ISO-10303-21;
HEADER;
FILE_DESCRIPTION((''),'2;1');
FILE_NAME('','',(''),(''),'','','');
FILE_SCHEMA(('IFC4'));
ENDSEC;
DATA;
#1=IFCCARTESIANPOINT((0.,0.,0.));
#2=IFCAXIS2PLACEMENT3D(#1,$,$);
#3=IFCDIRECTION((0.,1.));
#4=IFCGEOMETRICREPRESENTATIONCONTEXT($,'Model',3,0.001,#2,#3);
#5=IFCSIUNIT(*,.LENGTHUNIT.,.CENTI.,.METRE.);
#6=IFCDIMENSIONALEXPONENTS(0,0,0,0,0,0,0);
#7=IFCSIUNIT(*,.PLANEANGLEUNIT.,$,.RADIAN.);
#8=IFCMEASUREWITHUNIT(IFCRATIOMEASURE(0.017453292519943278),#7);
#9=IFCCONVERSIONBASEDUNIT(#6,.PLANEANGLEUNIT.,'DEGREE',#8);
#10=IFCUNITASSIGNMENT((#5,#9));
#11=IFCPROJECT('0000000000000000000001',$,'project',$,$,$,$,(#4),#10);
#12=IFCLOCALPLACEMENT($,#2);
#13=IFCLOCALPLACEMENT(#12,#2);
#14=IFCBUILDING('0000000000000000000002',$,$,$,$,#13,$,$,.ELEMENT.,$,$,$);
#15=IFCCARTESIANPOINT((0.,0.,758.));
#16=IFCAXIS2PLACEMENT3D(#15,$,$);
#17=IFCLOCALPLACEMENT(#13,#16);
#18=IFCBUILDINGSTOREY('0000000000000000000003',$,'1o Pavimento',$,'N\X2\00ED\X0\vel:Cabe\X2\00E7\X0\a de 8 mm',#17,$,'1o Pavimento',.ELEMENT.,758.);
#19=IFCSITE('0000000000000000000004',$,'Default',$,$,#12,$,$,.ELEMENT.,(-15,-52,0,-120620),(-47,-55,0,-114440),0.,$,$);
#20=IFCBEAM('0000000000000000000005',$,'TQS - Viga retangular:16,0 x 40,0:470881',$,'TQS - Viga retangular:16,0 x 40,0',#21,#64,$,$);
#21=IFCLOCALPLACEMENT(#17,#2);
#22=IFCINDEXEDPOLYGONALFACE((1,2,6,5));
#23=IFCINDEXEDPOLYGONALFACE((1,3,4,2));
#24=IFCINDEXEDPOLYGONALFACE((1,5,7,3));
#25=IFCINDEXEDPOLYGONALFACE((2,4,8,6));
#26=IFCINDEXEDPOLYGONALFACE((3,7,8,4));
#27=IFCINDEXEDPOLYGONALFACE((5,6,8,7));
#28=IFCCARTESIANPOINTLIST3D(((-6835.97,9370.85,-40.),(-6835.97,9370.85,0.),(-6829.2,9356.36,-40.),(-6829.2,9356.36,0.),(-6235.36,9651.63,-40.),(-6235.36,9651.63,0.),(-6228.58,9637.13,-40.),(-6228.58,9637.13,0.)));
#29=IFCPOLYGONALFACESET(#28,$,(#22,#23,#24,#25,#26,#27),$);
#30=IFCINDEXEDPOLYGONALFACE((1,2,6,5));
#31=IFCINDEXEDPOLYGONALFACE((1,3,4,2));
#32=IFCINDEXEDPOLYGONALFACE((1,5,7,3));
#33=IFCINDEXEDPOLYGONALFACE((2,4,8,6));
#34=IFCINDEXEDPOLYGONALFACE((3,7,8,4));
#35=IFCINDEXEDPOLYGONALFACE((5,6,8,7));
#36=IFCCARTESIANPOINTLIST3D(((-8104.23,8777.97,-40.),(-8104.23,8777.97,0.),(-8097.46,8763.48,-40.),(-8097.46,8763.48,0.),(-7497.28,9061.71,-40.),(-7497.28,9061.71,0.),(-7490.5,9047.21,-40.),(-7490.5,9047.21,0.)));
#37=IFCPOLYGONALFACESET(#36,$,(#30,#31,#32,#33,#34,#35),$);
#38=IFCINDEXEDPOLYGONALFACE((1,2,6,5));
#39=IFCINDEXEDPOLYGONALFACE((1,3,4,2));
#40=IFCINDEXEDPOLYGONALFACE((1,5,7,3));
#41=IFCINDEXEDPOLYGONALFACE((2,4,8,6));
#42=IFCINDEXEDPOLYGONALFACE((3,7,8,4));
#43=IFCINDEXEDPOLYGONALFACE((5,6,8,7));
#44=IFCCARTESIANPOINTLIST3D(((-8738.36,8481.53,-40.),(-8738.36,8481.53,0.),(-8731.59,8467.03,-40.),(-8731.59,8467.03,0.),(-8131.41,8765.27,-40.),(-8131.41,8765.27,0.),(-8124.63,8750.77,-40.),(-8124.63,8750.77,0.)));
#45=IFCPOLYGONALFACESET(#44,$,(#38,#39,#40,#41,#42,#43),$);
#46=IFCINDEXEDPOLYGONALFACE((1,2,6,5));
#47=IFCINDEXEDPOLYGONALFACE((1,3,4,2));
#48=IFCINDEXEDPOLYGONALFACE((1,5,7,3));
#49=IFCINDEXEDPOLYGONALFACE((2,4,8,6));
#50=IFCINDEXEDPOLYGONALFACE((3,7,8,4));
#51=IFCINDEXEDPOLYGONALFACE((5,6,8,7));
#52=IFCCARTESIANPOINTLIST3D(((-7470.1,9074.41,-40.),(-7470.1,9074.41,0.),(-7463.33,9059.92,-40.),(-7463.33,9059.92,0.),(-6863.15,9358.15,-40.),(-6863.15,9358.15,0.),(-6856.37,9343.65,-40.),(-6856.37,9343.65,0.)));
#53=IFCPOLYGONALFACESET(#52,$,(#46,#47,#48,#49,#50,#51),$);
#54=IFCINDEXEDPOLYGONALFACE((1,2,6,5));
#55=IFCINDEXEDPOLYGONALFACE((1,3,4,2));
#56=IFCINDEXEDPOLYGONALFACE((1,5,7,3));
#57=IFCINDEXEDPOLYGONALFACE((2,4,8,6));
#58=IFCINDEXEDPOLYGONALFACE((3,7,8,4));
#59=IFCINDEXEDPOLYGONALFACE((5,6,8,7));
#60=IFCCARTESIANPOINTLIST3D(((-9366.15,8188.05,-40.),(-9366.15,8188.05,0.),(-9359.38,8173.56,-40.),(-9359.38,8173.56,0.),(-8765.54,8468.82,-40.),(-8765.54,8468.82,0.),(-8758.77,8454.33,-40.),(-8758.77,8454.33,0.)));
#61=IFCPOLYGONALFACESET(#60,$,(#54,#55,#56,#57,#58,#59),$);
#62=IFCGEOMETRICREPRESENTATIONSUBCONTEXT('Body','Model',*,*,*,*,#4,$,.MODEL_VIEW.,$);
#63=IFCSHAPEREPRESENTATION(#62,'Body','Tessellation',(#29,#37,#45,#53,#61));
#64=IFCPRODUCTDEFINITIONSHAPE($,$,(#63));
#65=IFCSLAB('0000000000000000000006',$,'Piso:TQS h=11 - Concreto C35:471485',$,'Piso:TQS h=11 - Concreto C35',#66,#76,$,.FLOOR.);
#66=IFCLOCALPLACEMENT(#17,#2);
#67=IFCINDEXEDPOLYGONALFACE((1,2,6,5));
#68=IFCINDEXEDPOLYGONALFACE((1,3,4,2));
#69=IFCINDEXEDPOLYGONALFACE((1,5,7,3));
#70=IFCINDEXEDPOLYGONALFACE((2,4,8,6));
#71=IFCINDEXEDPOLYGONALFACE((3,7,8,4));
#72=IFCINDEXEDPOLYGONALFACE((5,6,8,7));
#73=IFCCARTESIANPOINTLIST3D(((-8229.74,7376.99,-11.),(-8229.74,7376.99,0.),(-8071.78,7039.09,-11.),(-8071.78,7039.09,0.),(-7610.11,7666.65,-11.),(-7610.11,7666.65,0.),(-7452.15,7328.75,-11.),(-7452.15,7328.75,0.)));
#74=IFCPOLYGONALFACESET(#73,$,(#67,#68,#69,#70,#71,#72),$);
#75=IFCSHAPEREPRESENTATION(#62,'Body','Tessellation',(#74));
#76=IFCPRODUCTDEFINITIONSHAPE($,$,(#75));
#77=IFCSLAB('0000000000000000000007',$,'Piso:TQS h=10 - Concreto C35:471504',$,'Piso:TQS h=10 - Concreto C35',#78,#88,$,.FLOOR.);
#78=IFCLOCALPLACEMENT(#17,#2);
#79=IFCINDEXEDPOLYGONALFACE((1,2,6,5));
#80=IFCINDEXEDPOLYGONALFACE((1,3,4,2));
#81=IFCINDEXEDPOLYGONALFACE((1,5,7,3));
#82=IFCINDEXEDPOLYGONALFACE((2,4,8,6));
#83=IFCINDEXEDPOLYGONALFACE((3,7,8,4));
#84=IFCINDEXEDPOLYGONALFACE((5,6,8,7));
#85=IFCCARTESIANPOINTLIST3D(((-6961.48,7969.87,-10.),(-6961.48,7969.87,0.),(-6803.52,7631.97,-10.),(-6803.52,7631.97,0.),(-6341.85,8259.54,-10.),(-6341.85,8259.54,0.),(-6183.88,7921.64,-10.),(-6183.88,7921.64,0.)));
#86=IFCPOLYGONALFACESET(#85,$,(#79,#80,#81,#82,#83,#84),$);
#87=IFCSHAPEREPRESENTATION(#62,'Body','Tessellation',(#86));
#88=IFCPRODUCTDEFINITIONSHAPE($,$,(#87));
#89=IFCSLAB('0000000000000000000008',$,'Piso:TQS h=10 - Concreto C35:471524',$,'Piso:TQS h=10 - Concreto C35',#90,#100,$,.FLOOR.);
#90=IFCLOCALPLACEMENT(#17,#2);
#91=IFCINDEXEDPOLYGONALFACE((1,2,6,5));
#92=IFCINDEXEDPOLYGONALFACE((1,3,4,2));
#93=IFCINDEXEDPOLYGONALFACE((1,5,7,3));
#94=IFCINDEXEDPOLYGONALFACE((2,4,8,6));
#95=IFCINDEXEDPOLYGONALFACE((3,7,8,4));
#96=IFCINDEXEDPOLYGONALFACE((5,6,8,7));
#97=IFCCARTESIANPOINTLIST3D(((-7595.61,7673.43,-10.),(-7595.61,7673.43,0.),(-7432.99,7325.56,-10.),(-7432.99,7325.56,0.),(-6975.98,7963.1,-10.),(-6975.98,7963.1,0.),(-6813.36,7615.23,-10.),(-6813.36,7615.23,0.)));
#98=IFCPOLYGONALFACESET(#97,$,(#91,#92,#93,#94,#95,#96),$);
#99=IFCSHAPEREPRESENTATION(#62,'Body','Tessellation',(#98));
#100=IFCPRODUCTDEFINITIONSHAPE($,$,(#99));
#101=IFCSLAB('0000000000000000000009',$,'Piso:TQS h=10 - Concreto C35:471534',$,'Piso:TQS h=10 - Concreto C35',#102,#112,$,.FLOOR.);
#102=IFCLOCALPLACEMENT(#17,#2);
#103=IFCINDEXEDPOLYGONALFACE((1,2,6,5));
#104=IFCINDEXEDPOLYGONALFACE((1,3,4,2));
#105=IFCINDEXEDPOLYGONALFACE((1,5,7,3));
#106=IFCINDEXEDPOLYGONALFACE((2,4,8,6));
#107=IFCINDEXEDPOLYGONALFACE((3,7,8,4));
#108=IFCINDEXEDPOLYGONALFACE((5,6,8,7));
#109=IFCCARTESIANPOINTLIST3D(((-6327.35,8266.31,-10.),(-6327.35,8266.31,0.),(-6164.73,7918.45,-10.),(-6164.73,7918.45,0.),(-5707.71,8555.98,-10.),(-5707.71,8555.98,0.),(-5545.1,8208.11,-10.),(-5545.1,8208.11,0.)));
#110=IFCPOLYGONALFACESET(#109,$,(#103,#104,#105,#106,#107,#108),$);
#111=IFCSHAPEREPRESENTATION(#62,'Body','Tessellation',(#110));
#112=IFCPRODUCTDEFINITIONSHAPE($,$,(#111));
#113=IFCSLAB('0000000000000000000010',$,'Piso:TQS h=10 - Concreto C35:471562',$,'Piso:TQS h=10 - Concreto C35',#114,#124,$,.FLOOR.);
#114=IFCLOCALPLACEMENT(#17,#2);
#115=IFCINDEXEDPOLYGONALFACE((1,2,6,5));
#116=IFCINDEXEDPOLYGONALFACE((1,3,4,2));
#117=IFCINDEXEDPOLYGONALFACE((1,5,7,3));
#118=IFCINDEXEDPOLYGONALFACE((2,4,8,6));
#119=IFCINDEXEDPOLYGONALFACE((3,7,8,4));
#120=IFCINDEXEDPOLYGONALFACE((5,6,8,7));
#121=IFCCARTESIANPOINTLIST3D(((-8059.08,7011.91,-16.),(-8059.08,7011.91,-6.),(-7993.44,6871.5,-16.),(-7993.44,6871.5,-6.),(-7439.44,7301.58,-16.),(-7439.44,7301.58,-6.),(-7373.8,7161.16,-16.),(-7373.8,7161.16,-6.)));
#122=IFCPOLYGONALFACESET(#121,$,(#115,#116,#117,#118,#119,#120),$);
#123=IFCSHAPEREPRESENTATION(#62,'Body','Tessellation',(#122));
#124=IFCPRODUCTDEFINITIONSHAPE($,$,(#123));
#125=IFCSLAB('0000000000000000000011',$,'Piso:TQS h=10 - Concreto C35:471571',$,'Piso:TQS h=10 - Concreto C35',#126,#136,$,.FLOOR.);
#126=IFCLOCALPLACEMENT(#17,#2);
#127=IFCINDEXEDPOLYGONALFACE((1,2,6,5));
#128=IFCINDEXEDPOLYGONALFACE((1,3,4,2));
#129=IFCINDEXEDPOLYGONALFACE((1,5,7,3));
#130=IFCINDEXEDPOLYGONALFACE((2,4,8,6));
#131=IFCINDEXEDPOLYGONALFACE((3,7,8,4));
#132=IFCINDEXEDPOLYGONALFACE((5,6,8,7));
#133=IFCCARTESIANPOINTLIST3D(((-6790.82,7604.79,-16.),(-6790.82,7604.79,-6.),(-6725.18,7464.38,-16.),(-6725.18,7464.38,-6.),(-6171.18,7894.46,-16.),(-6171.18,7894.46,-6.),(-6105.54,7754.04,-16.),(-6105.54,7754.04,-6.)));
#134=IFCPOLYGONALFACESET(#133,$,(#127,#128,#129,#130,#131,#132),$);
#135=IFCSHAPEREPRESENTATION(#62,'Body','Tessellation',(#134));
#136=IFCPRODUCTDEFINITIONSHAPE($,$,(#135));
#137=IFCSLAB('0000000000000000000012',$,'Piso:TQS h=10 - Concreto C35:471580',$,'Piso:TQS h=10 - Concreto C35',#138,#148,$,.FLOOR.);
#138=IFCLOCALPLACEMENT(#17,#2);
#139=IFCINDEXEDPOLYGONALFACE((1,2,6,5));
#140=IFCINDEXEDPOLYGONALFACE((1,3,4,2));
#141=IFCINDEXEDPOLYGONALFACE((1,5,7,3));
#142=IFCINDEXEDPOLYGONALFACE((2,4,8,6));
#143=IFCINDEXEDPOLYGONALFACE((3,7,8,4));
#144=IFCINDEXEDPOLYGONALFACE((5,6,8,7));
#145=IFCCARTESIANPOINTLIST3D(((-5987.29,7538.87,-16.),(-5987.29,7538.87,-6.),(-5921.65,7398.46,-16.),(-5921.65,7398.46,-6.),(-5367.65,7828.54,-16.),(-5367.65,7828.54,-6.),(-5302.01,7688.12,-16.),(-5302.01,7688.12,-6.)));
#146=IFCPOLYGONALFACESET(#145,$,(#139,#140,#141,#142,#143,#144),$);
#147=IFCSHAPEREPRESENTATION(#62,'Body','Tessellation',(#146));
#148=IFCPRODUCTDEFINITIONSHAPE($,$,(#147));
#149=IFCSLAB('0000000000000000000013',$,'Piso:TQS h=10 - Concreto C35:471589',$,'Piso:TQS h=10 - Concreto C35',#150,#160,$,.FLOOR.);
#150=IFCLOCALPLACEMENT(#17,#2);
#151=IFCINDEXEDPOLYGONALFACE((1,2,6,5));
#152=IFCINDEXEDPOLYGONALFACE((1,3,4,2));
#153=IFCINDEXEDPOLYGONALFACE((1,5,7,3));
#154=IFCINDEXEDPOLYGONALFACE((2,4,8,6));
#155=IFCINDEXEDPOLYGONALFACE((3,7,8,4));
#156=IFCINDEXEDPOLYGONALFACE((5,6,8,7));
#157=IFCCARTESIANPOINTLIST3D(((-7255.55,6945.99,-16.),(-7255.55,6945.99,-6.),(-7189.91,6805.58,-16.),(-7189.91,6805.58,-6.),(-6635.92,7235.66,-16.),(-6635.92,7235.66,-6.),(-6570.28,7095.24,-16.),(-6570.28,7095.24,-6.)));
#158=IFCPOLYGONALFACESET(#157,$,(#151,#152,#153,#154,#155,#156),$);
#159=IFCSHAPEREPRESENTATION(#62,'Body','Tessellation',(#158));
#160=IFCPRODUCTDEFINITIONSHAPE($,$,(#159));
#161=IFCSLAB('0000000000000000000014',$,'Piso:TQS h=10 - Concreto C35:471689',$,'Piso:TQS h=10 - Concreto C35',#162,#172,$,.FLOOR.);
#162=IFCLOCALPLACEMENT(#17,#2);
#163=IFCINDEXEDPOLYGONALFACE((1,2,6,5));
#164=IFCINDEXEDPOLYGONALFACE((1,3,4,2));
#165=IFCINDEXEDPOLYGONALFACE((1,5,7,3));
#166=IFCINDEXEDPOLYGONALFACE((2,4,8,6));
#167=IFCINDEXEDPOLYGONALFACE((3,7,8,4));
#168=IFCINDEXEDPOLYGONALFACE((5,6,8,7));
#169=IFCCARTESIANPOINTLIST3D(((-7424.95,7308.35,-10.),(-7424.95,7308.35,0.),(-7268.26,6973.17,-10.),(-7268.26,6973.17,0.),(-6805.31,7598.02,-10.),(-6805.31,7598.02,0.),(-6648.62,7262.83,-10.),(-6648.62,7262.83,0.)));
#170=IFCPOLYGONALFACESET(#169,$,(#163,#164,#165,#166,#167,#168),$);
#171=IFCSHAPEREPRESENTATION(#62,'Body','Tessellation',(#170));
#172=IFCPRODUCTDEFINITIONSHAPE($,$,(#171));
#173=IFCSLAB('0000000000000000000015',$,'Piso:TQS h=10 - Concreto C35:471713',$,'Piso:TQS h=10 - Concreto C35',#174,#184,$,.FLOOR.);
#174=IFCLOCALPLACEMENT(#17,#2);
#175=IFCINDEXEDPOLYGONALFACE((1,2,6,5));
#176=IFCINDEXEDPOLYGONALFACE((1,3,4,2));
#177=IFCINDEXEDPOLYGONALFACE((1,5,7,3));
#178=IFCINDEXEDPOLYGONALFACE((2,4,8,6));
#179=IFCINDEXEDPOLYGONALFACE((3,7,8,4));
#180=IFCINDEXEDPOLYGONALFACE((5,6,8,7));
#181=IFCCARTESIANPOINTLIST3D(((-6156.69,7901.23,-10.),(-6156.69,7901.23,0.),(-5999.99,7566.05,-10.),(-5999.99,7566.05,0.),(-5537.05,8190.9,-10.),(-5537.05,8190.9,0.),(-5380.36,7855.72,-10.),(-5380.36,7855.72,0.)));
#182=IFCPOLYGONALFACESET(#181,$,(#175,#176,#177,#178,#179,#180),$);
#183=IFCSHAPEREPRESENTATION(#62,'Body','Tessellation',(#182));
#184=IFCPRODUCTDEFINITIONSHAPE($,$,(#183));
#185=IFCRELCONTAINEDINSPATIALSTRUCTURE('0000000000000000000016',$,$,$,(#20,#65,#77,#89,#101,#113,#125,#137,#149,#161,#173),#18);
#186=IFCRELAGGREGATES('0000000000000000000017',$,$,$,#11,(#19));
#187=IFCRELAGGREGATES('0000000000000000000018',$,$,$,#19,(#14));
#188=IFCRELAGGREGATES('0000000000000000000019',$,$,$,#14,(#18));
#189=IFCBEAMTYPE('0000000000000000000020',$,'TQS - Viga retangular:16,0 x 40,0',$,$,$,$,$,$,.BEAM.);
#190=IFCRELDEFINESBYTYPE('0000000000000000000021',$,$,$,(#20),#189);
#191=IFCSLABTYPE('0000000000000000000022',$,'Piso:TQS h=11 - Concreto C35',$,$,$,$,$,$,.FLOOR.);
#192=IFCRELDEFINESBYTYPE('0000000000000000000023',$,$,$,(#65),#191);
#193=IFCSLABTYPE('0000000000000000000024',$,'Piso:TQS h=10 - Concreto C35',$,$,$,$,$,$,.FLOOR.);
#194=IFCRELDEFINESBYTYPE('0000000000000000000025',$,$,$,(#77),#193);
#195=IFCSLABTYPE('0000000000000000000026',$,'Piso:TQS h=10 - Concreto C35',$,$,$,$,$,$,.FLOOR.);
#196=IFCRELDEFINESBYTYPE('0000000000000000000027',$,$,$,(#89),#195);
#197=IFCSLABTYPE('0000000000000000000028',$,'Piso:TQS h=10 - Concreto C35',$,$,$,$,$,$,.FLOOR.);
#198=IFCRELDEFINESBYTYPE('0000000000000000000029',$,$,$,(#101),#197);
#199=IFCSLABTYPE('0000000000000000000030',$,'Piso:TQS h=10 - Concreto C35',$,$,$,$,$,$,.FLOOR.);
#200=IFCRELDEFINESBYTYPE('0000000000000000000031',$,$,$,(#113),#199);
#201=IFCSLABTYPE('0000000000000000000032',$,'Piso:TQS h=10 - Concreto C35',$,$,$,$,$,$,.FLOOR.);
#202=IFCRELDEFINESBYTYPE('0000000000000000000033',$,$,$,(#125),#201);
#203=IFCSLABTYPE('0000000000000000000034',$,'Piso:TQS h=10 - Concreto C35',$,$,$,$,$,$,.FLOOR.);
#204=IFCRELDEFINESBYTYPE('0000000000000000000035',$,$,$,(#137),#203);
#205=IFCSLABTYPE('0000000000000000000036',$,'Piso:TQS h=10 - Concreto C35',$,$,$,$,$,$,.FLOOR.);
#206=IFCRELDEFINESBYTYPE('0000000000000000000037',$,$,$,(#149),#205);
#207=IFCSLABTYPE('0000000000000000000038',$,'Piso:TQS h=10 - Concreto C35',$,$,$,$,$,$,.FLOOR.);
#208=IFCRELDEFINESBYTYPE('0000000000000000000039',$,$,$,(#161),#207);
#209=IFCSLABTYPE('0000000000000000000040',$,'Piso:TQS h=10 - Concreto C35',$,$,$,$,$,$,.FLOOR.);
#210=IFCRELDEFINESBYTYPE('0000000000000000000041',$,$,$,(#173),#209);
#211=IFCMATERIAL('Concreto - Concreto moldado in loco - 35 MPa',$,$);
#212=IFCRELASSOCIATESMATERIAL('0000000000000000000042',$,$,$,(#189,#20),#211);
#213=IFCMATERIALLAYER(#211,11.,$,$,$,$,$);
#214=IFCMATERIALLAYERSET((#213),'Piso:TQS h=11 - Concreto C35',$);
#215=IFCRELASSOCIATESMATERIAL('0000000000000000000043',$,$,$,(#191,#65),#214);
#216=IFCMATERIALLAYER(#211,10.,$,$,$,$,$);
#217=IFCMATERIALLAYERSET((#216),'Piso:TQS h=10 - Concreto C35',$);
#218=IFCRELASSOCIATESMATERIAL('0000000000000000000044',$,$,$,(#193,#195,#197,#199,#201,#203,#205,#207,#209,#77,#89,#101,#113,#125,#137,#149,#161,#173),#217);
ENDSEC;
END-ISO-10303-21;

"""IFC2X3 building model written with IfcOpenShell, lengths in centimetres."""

from ifc_helpers import new_model, entity, si_unit, converted_unit, direction, frame, frame_2d, origin, origin_2d_with_axis, place, context, subcontext, project, spatial, rectangle, extrude, source, transform, mapped, material, layer, layer_set, layer_usage, type_object, type_shapes, element, save


model = new_model("IFC2X3")

# Units and contexts
model_context = context("Model", 3, precision=0.001, world=origin(), true_north=direction((0.0, 1.0)))
body_context = subcontext(model_context, "Body", "Model", "MODEL_VIEW")
ifc_project = project(units=[si_unit("LENGTHUNIT", "METRE", prefix="CENTI"), converted_unit("PLANEANGLEUNIT", "DEGREE", entity("IfcRatioMeasure", 0.017453292519943278), si_unit("PLANEANGLEUNIT", "RADIAN"), dimensions=[0, 0, 0, 0, 0, 0, 0])], contexts=[model_context])

# Site, building, storey
site_placement = place(None, origin())
site = spatial("IfcSite", under=ifc_project, at=site_placement, Name="Default", CompositionType="ELEMENT", RefLatitude=(-15, -52, 0, -120620), RefLongitude=(-47, -55, 0, -114440), RefElevation=0.0)
building_placement = place(site_placement, origin())
building = spatial("IfcBuilding", under=site, at=building_placement, CompositionType="ELEMENT")
storey_placement = place(building_placement, frame((0.0, 0.0, 758.0)))
storey = spatial("IfcBuildingStorey", under=building, at=storey_placement, Name="1o Pavimento", ObjectType="Nível:Cabeça de 8 mm", LongName="1o Pavimento", CompositionType="ELEMENT", Elevation=758.0)

# Shared definitions
ifc_material = material(Name="Concreto - Concreto moldado in loco - 35 MPa")

# Beam
beam_type_1 = type_object("IfcBeamType", Name="TQS - Viga retangular:16,0 x 40,0", PredefinedType="BEAM", material=ifc_material)
shared_shape_1 = source(origin(), body_context, "Body", "SweptSolid", [
    extrude(rectangle(XDim=40.0, YDim=16.0, at=origin_2d_with_axis()), frame((-6832.58, 9363.61, 738.0), z_axis=(0.905902, 0.423488, 0.0), x_axis=(0.0, 0.0, 1.0)), (0.0, 0.0, 1.0), 663.0),
    extrude(rectangle(XDim=40.0, YDim=16.0, at=frame_2d((0.0, 0.0), x_axis=(1.0, 0.0))), frame((-8100.85, 8770.72, 738.0), z_axis=(0.905902, 0.423488, 0.0), x_axis=(0.0, 0.0, 1.0)), (0.0, 0.0, 1.0), 670.0),
    extrude(rectangle(XDim=40.0, YDim=16.0, at=origin_2d_with_axis()), frame((-8734.98, 8474.28, 738.0), z_axis=(0.905902, 0.423488, 0.0), x_axis=(0.0, 0.0, 1.0)), (0.0, 0.0, 1.0), 670.0),
    extrude(rectangle(XDim=40.0, YDim=16.0, at=frame_2d((0.0, 0.0), x_axis=(1.0, 0.0))), frame((-7466.71, 9067.16, 738.0), z_axis=(0.905902, 0.423488, 0.0), x_axis=(0.0, 0.0, 1.0)), (0.0, 0.0, 1.0), 670.0),
    extrude(rectangle(XDim=40.0, YDim=16.0, at=frame_2d((0.0, 0.0), x_axis=(1.0, 0.0))), frame((-9362.77, 8180.81, 738.0), z_axis=(0.905902, 0.423488, 0.0), x_axis=(0.0, 0.0, 1.0)), (0.0, 0.0, 1.0), 663.0),
])
type_shapes(beam_type_1, [shared_shape_1])
beam_1_placement = place(storey_placement, frame((0.0, 0.0, -758.0)))
element("IfcBeam", 1, at=beam_1_placement, inside=storey, type_object=beam_type_1, material=ifc_material, Name="TQS - Viga retangular:16,0 x 40,0:470881", ObjectType="TQS - Viga retangular:16,0 x 40,0", context=body_context, shape_type="MappedRepresentation", body=[
    mapped(shared_shape_1, transform((0.0, 0.0, 0.0), scale=1.0)),
])

# Slabs
ifc_layer_1 = layer(ifc_material, 11.0)
ifc_layer_set_1 = layer_set([ifc_layer_1], Name="Piso:TQS h=11 - Concreto C35")
ifc_layer_usage_1 = layer_usage(ifc_layer_set_1, "AXIS3", "POSITIVE", 0.0)
slab_type_1 = type_object("IfcSlabType", Name="Piso:TQS h=11 - Concreto C35", PredefinedType="FLOOR", material=ifc_layer_set_1)
slab_1_placement = place(storey_placement, origin())
element("IfcSlab", 2, at=slab_1_placement, inside=storey, type_object=slab_type_1, material=ifc_layer_usage_1, Name="Piso:TQS h=11 - Concreto C35:471485", ObjectType="Piso:TQS h=11 - Concreto C35", PredefinedType="FLOOR", context=body_context, shape_type="SweptSolid", body=[
    extrude(rectangle(XDim=684.0, YDim=373.0, at=frame_2d((0.0, 0.0), x_axis=(1.0, 0.0))), frame((-7840.95, 7352.87, 0.0), z_axis=(0.0, 0.0, -1.0), x_axis=(-0.905902, -0.423488, 0.0)), (0.0, 0.0, 1.0), 11.0),
])
ifc_layer_2 = layer(ifc_material, 10.0)
ifc_layer_set_2 = layer_set([ifc_layer_2], Name="Piso:TQS h=10 - Concreto C35")
ifc_layer_usage_2 = layer_usage(ifc_layer_set_2, "AXIS3", "POSITIVE", 0.0)
slab_type_2 = type_object("IfcSlabType", Name="Piso:TQS h=10 - Concreto C35", PredefinedType="FLOOR", material=ifc_layer_set_2)
slab_2_placement = place(storey_placement, origin())
element("IfcSlab", 3, at=slab_2_placement, inside=storey, type_object=slab_type_2, material=ifc_layer_usage_2, Name="Piso:TQS h=10 - Concreto C35:471504", ObjectType="Piso:TQS h=10 - Concreto C35", PredefinedType="FLOOR", context=body_context, shape_type="SweptSolid", body=[
    extrude(rectangle(XDim=684.0, YDim=373.0, at=frame_2d((0.0, 0.0), x_axis=(1.0, 0.0))), frame((-6572.68, 7945.75, 0.0), z_axis=(0.0, 0.0, -1.0), x_axis=(0.905902, 0.423488, 0.0)), (0.0, 0.0, 1.0), 10.0),
])
ifc_layer_usage_3 = layer_usage(ifc_layer_set_2, "AXIS3", "POSITIVE", 0.0)
slab_type_3 = type_object("IfcSlabType", Name="Piso:TQS h=10 - Concreto C35", PredefinedType="FLOOR", material=ifc_layer_set_2)
slab_3_placement = place(storey_placement, origin())
element("IfcSlab", 4, at=slab_3_placement, inside=storey, type_object=slab_type_3, material=ifc_layer_usage_3, Name="Piso:TQS h=10 - Concreto C35:471524", ObjectType="Piso:TQS h=10 - Concreto C35", PredefinedType="FLOOR", context=body_context, shape_type="SweptSolid", body=[
    extrude(rectangle(XDim=384.0, YDim=684.0, at=frame_2d((0.0, 0.0), x_axis=(1.0, 0.0))), frame((-7204.49, 7644.33, 0.0), z_axis=(0.0, 0.0, -1.0), x_axis=(0.423488, -0.905902, 0.0)), (0.0, 0.0, 1.0), 10.0),
])
ifc_layer_usage_4 = layer_usage(ifc_layer_set_2, "AXIS3", "POSITIVE", 0.0)
slab_type_4 = type_object("IfcSlabType", Name="Piso:TQS h=10 - Concreto C35", PredefinedType="FLOOR", material=ifc_layer_set_2)
slab_4_placement = place(storey_placement, origin())
element("IfcSlab", 5, at=slab_4_placement, inside=storey, type_object=slab_type_4, material=ifc_layer_usage_4, Name="Piso:TQS h=10 - Concreto C35:471534", ObjectType="Piso:TQS h=10 - Concreto C35", PredefinedType="FLOOR", context=body_context, shape_type="SweptSolid", body=[
    extrude(rectangle(XDim=684.0, YDim=384.0, at=frame_2d((0.0, 0.0), x_axis=(1.0, 0.0))), frame((-5936.22, 8237.21, 0.0), z_axis=(0.0, 0.0, -1.0), x_axis=(0.905902, 0.423488, 0.0)), (0.0, 0.0, 1.0), 10.0),
])
ifc_layer_usage_5 = layer_usage(ifc_layer_set_2, "AXIS3", "POSITIVE", 0.0)
slab_type_5 = type_object("IfcSlabType", Name="Piso:TQS h=10 - Concreto C35", PredefinedType="FLOOR", material=ifc_layer_set_2)
slab_5_placement = place(storey_placement, origin())
element("IfcSlab", 6, at=slab_5_placement, inside=storey, type_object=slab_type_5, material=ifc_layer_usage_5, Name="Piso:TQS h=10 - Concreto C35:471562", ObjectType="Piso:TQS h=10 - Concreto C35", PredefinedType="FLOOR", context=body_context, shape_type="SweptSolid", body=[
    extrude(rectangle(XDim=155.0, YDim=684.0, at=frame_2d((0.0, 0.0), x_axis=(1.0, 0.0))), frame((-7716.44, 7086.54, -6.0), z_axis=(0.0, 0.0, -1.0), x_axis=(0.423488, -0.905902, 0.0)), (0.0, 0.0, 1.0), 10.0),
])
ifc_layer_usage_6 = layer_usage(ifc_layer_set_2, "AXIS3", "POSITIVE", 0.0)
slab_type_6 = type_object("IfcSlabType", Name="Piso:TQS h=10 - Concreto C35", PredefinedType="FLOOR", material=ifc_layer_set_2)
slab_6_placement = place(storey_placement, origin())
element("IfcSlab", 7, at=slab_6_placement, inside=storey, type_object=slab_type_6, material=ifc_layer_usage_6, Name="Piso:TQS h=10 - Concreto C35:471571", ObjectType="Piso:TQS h=10 - Concreto C35", PredefinedType="FLOOR", context=body_context, shape_type="SweptSolid", body=[
    extrude(rectangle(XDim=155.0, YDim=684.0, at=frame_2d((0.0, 0.0), x_axis=(1.0, 0.0))), frame((-6448.18, 7679.42, -6.0), z_axis=(0.0, 0.0, -1.0), x_axis=(0.423488, -0.905902, 0.0)), (0.0, 0.0, 1.0), 10.0),
])
ifc_layer_usage_7 = layer_usage(ifc_layer_set_2, "AXIS3", "POSITIVE", 0.0)
slab_type_7 = type_object("IfcSlabType", Name="Piso:TQS h=10 - Concreto C35", PredefinedType="FLOOR", material=ifc_layer_set_2)
slab_7_placement = place(storey_placement, origin())
element("IfcSlab", 8, at=slab_7_placement, inside=storey, type_object=slab_type_7, material=ifc_layer_usage_7, Name="Piso:TQS h=10 - Concreto C35:471580", ObjectType="Piso:TQS h=10 - Concreto C35", PredefinedType="FLOOR", context=body_context, shape_type="SweptSolid", body=[
    extrude(rectangle(XDim=684.0, YDim=155.0, at=frame_2d((0.0, 0.0), x_axis=(1.0, 0.0))), frame((-5644.65, 7613.5, -6.0), z_axis=(0.0, 0.0, -1.0), x_axis=(0.905902, 0.423488, 0.0)), (0.0, 0.0, 1.0), 10.0),
])
ifc_layer_usage_8 = layer_usage(ifc_layer_set_2, "AXIS3", "POSITIVE", 0.0)
slab_type_8 = type_object("IfcSlabType", Name="Piso:TQS h=10 - Concreto C35", PredefinedType="FLOOR", material=ifc_layer_set_2)
slab_8_placement = place(storey_placement, origin())
element("IfcSlab", 9, at=slab_8_placement, inside=storey, type_object=slab_type_8, material=ifc_layer_usage_8, Name="Piso:TQS h=10 - Concreto C35:471589", ObjectType="Piso:TQS h=10 - Concreto C35", PredefinedType="FLOOR", context=body_context, shape_type="SweptSolid", body=[
    extrude(rectangle(XDim=684.0, YDim=155.0, at=frame_2d((0.0, 0.0), x_axis=(1.0, 0.0))), frame((-6912.91, 7020.62, -6.0), z_axis=(0.0, 0.0, -1.0), x_axis=(0.905902, 0.423488, 0.0)), (0.0, 0.0, 1.0), 10.0),
])
ifc_layer_usage_9 = layer_usage(ifc_layer_set_2, "AXIS3", "POSITIVE", 0.0)
slab_type_9 = type_object("IfcSlabType", Name="Piso:TQS h=10 - Concreto C35", PredefinedType="FLOOR", material=ifc_layer_set_2)
slab_9_placement = place(storey_placement, origin())
element("IfcSlab", 10, at=slab_9_placement, inside=storey, type_object=slab_type_9, material=ifc_layer_usage_9, Name="Piso:TQS h=10 - Concreto C35:471689", ObjectType="Piso:TQS h=10 - Concreto C35", PredefinedType="FLOOR", context=body_context, shape_type="SweptSolid", body=[
    extrude(rectangle(XDim=684.0, YDim=370.0, at=origin_2d_with_axis()), frame((-7036.78, 7285.59, 0.0), z_axis=(0.0, 0.0, -1.0), x_axis=(-0.905902, -0.423488, 0.0)), (0.0, 0.0, 1.0), 10.0),
])
ifc_layer_usage_10 = layer_usage(ifc_layer_set_2, "AXIS3", "POSITIVE", 0.0)
slab_type_10 = type_object("IfcSlabType", Name="Piso:TQS h=10 - Concreto C35", PredefinedType="FLOOR", material=ifc_layer_set_2)
slab_10_placement = place(storey_placement, origin())
element("IfcSlab", 11, at=slab_10_placement, inside=storey, type_object=slab_type_10, material=ifc_layer_usage_10, Name="Piso:TQS h=10 - Concreto C35:471713", ObjectType="Piso:TQS h=10 - Concreto C35", PredefinedType="FLOOR", context=body_context, shape_type="SweptSolid", body=[
    extrude(rectangle(XDim=370.0, YDim=684.0, at=frame_2d((0.0, 0.0), x_axis=(1.0, 0.0))), frame((-5768.52, 7878.48, 0.0), z_axis=(0.0, 0.0, -1.0), x_axis=(0.423488, -0.905902, 0.0)), (0.0, 0.0, 1.0), 10.0),
])

save(model, "model.ifc")
